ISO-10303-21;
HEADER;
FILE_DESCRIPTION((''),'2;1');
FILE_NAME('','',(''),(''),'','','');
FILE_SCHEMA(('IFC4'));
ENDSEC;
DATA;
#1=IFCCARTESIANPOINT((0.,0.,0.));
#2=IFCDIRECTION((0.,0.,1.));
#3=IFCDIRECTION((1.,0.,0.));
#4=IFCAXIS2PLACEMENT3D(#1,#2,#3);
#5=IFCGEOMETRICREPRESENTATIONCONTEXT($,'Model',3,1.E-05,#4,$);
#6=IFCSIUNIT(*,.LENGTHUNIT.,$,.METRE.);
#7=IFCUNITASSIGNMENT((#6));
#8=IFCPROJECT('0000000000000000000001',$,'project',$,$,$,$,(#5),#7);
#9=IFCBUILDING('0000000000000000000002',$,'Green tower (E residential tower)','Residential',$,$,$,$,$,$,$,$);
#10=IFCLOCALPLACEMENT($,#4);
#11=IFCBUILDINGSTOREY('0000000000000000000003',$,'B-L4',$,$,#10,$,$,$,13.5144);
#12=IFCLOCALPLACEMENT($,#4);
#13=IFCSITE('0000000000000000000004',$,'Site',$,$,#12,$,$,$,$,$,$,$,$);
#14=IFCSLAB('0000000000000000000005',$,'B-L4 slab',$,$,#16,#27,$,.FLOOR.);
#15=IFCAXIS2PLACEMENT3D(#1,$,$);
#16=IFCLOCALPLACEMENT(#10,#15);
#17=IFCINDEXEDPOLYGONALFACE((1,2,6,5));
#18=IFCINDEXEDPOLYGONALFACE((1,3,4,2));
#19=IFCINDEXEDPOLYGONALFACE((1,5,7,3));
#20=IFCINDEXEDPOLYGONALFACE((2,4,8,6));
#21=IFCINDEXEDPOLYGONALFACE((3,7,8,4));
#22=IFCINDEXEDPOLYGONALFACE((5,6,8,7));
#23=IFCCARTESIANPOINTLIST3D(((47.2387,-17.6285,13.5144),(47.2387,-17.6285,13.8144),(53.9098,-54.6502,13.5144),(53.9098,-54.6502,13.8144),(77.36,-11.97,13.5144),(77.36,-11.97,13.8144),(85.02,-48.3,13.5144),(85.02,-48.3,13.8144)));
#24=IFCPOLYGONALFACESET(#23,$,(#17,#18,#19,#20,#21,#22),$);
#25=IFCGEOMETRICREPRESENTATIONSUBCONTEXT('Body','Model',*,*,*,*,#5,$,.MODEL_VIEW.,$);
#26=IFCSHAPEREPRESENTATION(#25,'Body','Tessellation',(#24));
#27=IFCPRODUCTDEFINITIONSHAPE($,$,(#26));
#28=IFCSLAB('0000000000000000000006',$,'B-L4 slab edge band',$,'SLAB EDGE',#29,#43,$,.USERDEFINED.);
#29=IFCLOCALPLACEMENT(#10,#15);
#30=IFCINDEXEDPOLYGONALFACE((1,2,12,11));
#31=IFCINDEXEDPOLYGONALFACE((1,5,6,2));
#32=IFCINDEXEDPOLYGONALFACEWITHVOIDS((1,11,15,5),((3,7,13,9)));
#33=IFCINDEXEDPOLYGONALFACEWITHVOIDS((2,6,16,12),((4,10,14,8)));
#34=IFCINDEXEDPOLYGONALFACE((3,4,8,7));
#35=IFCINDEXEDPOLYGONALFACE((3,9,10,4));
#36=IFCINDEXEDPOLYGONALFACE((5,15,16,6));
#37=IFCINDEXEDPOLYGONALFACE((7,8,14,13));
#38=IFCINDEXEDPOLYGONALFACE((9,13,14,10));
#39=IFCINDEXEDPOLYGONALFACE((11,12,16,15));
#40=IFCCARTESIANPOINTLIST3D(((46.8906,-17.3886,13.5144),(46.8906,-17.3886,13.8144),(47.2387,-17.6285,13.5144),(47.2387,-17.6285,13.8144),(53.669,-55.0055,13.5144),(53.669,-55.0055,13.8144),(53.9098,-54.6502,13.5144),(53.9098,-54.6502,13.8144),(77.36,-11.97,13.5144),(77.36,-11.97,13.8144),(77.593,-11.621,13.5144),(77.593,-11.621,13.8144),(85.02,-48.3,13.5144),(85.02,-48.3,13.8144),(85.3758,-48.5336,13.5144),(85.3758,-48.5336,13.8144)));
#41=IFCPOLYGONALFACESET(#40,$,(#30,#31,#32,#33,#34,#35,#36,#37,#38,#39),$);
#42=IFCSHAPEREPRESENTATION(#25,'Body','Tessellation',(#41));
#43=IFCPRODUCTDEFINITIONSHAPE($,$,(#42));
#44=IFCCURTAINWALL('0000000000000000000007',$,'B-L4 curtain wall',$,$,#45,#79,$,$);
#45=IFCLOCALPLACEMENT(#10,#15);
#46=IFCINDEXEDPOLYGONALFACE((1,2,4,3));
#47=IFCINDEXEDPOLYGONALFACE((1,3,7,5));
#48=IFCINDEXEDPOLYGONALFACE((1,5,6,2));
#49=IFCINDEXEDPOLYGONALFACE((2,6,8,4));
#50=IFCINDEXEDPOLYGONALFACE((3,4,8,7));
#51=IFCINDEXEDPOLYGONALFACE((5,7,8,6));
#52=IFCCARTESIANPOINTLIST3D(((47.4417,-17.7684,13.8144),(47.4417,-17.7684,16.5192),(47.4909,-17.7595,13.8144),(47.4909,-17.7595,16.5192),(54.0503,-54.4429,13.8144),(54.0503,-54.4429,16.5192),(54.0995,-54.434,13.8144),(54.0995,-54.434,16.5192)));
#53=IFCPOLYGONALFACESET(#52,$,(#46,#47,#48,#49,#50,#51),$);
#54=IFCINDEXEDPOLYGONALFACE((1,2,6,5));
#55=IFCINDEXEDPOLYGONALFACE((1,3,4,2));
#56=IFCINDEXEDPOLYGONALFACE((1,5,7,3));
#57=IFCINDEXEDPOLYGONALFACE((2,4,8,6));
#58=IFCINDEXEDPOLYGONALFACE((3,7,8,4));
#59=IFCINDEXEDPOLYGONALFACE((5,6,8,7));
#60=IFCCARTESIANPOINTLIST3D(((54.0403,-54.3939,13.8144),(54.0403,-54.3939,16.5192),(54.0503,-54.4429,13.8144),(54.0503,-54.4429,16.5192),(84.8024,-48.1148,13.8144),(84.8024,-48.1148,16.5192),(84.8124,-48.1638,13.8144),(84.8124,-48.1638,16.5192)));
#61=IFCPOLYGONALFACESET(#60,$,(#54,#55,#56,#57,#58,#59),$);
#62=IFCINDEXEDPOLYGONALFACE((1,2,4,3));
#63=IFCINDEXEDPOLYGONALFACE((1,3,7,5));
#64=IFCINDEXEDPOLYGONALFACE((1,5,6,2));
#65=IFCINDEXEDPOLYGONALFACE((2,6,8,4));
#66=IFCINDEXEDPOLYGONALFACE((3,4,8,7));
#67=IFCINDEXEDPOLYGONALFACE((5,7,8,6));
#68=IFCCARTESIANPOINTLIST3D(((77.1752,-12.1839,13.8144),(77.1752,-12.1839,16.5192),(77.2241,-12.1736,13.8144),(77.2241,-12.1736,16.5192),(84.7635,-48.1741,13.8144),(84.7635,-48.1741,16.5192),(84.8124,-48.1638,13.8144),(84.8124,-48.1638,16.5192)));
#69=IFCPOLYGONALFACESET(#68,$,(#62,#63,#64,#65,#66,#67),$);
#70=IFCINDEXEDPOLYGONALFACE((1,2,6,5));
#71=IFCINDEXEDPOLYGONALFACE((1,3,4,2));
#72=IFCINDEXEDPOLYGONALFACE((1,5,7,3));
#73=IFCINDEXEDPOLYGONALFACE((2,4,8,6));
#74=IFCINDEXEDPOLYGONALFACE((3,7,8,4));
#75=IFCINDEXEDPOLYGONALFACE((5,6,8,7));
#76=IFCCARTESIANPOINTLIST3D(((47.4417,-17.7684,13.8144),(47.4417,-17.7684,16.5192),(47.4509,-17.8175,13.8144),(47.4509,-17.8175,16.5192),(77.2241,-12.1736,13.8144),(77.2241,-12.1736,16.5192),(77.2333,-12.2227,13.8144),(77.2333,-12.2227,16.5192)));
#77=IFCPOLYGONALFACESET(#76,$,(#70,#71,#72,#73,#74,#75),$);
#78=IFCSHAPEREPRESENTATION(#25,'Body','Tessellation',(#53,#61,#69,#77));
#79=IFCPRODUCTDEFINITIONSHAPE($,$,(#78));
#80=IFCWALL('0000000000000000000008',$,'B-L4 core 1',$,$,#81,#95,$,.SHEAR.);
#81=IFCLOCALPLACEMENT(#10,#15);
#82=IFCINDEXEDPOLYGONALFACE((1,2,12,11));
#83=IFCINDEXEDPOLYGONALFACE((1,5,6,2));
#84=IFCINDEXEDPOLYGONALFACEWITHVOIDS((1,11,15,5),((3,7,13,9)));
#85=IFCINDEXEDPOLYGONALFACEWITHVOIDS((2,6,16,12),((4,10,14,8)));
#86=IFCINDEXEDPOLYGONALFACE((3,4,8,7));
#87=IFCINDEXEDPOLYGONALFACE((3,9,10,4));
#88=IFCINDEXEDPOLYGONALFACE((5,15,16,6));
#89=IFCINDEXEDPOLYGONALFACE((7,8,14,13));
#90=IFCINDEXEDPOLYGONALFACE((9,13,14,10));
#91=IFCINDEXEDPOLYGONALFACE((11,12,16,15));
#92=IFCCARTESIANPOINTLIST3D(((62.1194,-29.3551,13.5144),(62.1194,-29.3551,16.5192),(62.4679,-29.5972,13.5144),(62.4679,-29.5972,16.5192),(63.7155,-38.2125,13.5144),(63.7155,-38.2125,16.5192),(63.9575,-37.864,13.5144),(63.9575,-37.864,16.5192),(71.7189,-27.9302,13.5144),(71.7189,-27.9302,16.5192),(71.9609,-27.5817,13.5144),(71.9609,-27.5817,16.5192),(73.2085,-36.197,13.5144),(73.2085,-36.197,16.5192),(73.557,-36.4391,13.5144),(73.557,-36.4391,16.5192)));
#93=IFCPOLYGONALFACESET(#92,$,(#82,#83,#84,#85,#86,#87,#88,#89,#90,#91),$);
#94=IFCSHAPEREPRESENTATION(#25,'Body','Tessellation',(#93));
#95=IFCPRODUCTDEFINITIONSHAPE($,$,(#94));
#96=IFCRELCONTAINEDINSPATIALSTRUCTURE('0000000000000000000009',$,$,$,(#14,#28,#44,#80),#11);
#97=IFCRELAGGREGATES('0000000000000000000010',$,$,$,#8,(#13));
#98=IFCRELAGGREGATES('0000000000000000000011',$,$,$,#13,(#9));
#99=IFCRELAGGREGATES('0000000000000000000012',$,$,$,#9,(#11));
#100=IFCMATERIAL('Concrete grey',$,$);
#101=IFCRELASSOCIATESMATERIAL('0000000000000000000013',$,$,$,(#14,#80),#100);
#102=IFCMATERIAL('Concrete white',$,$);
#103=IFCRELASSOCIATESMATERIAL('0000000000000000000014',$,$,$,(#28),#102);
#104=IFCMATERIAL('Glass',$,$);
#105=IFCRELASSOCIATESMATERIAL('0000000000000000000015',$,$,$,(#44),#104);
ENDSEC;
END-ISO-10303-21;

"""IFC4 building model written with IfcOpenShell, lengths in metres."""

from ifc_helpers import new_model, si_unit, frame, origin_with_axes, place, context, subcontext, project, spatial, polyline, outline, extrude, material, element, save


model = new_model("IFC4")

# Units and contexts
model_context = context("Model", 3, precision=1e-05, world=origin_with_axes())
body_context = subcontext(model_context, "Body", "Model", "MODEL_VIEW")
ifc_project = project(units=[si_unit("LENGTHUNIT", "METRE")], contexts=[model_context])

# Site, building, storey
site_placement = place(None, origin_with_axes())
site = spatial("IfcSite", under=ifc_project, at=site_placement, Name="Site")
building = spatial("IfcBuilding", under=site, Name="Green tower (E residential tower)", Description="Residential")
storey_placement = place(None, origin_with_axes())
storey = spatial("IfcBuildingStorey", under=building, at=storey_placement, Name="B-L4", Elevation=13.5144)

# Slabs
ifc_material_1 = material(Name="Concrete grey")
slab_1_placement = place(storey_placement, origin_with_axes())
element("IfcSlab", 1, at=slab_1_placement, inside=storey, material=ifc_material_1, Name="B-L4 slab", PredefinedType="FLOOR", context=body_context, shape_type="SweptSolid", body=[
    extrude(outline(polyline([(47.2387, -17.6285), (53.9098, -54.6502), (85.02, -48.3), (77.36, -11.97), (47.2387, -17.6285)])), frame((0.0, 0.0, 13.5144), z_axis=(0.0, 0.0, 1.0), x_axis=(1.0, 0.0, 0.0)), (0.0, 0.0, 1.0), 0.3),
])
ifc_material_2 = material(Name="Concrete white")
slab_2_placement = place(storey_placement, origin_with_axes())
element("IfcSlab", 2, at=slab_2_placement, inside=storey, material=ifc_material_2, Name="B-L4 slab edge band", ObjectType="SLAB EDGE", PredefinedType="USERDEFINED", context=body_context, shape_type="SweptSolid", body=[
    extrude(outline(polyline([(46.8906, -17.3886), (53.669, -55.0055), (85.3758, -48.5336), (77.593, -11.621), (46.8906, -17.3886)]), holes=[polyline([(47.2387, -17.6285), (53.9098, -54.6502), (85.02, -48.3), (77.36, -11.97), (47.2387, -17.6285)])]), frame((0.0, 0.0, 13.5144), z_axis=(0.0, 0.0, 1.0), x_axis=(1.0, 0.0, 0.0)), (0.0, 0.0, 1.0), 0.3),
])

# Curtain wall
ifc_material_3 = material(Name="Glass")
curtain_wall_placement = place(storey_placement, origin_with_axes())
element("IfcCurtainWall", 3, at=curtain_wall_placement, inside=storey, material=ifc_material_3, Name="B-L4 curtain wall", context=body_context, shape_type="SweptSolid", body=[
    extrude(outline(polyline([(47.4417, -17.7684), (54.0503, -54.4429), (54.0995, -54.434), (47.4909, -17.7595), (47.4417, -17.7684)])), frame((0.0, 0.0, 13.8144), z_axis=(0.0, 0.0, 1.0), x_axis=(1.0, 0.0, 0.0)), (0.0, 0.0, 1.0), 2.7048),
    extrude(outline(polyline([(54.0503, -54.4429), (84.8124, -48.1638), (84.8024, -48.1148), (54.0403, -54.3939), (54.0503, -54.4429)])), frame((0.0, 0.0, 13.8144), z_axis=(0.0, 0.0, 1.0), x_axis=(1.0, 0.0, 0.0)), (0.0, 0.0, 1.0), 2.7048),
    extrude(outline(polyline([(84.8124, -48.1638), (77.2241, -12.1736), (77.1752, -12.1839), (84.7635, -48.1741), (84.8124, -48.1638)])), frame((0.0, 0.0, 13.8144), z_axis=(0.0, 0.0, 1.0), x_axis=(1.0, 0.0, 0.0)), (0.0, 0.0, 1.0), 2.7048),
    extrude(outline(polyline([(77.2241, -12.1736), (47.4417, -17.7684), (47.4509, -17.8175), (77.2333, -12.2227), (77.2241, -12.1736)])), frame((0.0, 0.0, 13.8144), z_axis=(0.0, 0.0, 1.0), x_axis=(1.0, 0.0, 0.0)), (0.0, 0.0, 1.0), 2.7048),
])

# Wall
wall_placement = place(storey_placement, origin_with_axes())
element("IfcWall", 4, at=wall_placement, inside=storey, material=ifc_material_1, Name="B-L4 core 1", PredefinedType="SHEAR", context=body_context, shape_type="SweptSolid", body=[
    extrude(outline(polyline([(62.1194, -29.3551), (63.7155, -38.2125), (73.557, -36.4391), (71.9609, -27.5817), (62.1194, -29.3551)]), holes=[polyline([(62.4679, -29.5972), (63.9575, -37.864), (73.2085, -36.197), (71.7189, -27.9302), (62.4679, -29.5972)])]), frame((0.0, 0.0, 13.5144), z_axis=(0.0, 0.0, 1.0), x_axis=(1.0, 0.0, 0.0)), (0.0, 0.0, 1.0), 3.0048),
])

save(model, "model.ifc")
